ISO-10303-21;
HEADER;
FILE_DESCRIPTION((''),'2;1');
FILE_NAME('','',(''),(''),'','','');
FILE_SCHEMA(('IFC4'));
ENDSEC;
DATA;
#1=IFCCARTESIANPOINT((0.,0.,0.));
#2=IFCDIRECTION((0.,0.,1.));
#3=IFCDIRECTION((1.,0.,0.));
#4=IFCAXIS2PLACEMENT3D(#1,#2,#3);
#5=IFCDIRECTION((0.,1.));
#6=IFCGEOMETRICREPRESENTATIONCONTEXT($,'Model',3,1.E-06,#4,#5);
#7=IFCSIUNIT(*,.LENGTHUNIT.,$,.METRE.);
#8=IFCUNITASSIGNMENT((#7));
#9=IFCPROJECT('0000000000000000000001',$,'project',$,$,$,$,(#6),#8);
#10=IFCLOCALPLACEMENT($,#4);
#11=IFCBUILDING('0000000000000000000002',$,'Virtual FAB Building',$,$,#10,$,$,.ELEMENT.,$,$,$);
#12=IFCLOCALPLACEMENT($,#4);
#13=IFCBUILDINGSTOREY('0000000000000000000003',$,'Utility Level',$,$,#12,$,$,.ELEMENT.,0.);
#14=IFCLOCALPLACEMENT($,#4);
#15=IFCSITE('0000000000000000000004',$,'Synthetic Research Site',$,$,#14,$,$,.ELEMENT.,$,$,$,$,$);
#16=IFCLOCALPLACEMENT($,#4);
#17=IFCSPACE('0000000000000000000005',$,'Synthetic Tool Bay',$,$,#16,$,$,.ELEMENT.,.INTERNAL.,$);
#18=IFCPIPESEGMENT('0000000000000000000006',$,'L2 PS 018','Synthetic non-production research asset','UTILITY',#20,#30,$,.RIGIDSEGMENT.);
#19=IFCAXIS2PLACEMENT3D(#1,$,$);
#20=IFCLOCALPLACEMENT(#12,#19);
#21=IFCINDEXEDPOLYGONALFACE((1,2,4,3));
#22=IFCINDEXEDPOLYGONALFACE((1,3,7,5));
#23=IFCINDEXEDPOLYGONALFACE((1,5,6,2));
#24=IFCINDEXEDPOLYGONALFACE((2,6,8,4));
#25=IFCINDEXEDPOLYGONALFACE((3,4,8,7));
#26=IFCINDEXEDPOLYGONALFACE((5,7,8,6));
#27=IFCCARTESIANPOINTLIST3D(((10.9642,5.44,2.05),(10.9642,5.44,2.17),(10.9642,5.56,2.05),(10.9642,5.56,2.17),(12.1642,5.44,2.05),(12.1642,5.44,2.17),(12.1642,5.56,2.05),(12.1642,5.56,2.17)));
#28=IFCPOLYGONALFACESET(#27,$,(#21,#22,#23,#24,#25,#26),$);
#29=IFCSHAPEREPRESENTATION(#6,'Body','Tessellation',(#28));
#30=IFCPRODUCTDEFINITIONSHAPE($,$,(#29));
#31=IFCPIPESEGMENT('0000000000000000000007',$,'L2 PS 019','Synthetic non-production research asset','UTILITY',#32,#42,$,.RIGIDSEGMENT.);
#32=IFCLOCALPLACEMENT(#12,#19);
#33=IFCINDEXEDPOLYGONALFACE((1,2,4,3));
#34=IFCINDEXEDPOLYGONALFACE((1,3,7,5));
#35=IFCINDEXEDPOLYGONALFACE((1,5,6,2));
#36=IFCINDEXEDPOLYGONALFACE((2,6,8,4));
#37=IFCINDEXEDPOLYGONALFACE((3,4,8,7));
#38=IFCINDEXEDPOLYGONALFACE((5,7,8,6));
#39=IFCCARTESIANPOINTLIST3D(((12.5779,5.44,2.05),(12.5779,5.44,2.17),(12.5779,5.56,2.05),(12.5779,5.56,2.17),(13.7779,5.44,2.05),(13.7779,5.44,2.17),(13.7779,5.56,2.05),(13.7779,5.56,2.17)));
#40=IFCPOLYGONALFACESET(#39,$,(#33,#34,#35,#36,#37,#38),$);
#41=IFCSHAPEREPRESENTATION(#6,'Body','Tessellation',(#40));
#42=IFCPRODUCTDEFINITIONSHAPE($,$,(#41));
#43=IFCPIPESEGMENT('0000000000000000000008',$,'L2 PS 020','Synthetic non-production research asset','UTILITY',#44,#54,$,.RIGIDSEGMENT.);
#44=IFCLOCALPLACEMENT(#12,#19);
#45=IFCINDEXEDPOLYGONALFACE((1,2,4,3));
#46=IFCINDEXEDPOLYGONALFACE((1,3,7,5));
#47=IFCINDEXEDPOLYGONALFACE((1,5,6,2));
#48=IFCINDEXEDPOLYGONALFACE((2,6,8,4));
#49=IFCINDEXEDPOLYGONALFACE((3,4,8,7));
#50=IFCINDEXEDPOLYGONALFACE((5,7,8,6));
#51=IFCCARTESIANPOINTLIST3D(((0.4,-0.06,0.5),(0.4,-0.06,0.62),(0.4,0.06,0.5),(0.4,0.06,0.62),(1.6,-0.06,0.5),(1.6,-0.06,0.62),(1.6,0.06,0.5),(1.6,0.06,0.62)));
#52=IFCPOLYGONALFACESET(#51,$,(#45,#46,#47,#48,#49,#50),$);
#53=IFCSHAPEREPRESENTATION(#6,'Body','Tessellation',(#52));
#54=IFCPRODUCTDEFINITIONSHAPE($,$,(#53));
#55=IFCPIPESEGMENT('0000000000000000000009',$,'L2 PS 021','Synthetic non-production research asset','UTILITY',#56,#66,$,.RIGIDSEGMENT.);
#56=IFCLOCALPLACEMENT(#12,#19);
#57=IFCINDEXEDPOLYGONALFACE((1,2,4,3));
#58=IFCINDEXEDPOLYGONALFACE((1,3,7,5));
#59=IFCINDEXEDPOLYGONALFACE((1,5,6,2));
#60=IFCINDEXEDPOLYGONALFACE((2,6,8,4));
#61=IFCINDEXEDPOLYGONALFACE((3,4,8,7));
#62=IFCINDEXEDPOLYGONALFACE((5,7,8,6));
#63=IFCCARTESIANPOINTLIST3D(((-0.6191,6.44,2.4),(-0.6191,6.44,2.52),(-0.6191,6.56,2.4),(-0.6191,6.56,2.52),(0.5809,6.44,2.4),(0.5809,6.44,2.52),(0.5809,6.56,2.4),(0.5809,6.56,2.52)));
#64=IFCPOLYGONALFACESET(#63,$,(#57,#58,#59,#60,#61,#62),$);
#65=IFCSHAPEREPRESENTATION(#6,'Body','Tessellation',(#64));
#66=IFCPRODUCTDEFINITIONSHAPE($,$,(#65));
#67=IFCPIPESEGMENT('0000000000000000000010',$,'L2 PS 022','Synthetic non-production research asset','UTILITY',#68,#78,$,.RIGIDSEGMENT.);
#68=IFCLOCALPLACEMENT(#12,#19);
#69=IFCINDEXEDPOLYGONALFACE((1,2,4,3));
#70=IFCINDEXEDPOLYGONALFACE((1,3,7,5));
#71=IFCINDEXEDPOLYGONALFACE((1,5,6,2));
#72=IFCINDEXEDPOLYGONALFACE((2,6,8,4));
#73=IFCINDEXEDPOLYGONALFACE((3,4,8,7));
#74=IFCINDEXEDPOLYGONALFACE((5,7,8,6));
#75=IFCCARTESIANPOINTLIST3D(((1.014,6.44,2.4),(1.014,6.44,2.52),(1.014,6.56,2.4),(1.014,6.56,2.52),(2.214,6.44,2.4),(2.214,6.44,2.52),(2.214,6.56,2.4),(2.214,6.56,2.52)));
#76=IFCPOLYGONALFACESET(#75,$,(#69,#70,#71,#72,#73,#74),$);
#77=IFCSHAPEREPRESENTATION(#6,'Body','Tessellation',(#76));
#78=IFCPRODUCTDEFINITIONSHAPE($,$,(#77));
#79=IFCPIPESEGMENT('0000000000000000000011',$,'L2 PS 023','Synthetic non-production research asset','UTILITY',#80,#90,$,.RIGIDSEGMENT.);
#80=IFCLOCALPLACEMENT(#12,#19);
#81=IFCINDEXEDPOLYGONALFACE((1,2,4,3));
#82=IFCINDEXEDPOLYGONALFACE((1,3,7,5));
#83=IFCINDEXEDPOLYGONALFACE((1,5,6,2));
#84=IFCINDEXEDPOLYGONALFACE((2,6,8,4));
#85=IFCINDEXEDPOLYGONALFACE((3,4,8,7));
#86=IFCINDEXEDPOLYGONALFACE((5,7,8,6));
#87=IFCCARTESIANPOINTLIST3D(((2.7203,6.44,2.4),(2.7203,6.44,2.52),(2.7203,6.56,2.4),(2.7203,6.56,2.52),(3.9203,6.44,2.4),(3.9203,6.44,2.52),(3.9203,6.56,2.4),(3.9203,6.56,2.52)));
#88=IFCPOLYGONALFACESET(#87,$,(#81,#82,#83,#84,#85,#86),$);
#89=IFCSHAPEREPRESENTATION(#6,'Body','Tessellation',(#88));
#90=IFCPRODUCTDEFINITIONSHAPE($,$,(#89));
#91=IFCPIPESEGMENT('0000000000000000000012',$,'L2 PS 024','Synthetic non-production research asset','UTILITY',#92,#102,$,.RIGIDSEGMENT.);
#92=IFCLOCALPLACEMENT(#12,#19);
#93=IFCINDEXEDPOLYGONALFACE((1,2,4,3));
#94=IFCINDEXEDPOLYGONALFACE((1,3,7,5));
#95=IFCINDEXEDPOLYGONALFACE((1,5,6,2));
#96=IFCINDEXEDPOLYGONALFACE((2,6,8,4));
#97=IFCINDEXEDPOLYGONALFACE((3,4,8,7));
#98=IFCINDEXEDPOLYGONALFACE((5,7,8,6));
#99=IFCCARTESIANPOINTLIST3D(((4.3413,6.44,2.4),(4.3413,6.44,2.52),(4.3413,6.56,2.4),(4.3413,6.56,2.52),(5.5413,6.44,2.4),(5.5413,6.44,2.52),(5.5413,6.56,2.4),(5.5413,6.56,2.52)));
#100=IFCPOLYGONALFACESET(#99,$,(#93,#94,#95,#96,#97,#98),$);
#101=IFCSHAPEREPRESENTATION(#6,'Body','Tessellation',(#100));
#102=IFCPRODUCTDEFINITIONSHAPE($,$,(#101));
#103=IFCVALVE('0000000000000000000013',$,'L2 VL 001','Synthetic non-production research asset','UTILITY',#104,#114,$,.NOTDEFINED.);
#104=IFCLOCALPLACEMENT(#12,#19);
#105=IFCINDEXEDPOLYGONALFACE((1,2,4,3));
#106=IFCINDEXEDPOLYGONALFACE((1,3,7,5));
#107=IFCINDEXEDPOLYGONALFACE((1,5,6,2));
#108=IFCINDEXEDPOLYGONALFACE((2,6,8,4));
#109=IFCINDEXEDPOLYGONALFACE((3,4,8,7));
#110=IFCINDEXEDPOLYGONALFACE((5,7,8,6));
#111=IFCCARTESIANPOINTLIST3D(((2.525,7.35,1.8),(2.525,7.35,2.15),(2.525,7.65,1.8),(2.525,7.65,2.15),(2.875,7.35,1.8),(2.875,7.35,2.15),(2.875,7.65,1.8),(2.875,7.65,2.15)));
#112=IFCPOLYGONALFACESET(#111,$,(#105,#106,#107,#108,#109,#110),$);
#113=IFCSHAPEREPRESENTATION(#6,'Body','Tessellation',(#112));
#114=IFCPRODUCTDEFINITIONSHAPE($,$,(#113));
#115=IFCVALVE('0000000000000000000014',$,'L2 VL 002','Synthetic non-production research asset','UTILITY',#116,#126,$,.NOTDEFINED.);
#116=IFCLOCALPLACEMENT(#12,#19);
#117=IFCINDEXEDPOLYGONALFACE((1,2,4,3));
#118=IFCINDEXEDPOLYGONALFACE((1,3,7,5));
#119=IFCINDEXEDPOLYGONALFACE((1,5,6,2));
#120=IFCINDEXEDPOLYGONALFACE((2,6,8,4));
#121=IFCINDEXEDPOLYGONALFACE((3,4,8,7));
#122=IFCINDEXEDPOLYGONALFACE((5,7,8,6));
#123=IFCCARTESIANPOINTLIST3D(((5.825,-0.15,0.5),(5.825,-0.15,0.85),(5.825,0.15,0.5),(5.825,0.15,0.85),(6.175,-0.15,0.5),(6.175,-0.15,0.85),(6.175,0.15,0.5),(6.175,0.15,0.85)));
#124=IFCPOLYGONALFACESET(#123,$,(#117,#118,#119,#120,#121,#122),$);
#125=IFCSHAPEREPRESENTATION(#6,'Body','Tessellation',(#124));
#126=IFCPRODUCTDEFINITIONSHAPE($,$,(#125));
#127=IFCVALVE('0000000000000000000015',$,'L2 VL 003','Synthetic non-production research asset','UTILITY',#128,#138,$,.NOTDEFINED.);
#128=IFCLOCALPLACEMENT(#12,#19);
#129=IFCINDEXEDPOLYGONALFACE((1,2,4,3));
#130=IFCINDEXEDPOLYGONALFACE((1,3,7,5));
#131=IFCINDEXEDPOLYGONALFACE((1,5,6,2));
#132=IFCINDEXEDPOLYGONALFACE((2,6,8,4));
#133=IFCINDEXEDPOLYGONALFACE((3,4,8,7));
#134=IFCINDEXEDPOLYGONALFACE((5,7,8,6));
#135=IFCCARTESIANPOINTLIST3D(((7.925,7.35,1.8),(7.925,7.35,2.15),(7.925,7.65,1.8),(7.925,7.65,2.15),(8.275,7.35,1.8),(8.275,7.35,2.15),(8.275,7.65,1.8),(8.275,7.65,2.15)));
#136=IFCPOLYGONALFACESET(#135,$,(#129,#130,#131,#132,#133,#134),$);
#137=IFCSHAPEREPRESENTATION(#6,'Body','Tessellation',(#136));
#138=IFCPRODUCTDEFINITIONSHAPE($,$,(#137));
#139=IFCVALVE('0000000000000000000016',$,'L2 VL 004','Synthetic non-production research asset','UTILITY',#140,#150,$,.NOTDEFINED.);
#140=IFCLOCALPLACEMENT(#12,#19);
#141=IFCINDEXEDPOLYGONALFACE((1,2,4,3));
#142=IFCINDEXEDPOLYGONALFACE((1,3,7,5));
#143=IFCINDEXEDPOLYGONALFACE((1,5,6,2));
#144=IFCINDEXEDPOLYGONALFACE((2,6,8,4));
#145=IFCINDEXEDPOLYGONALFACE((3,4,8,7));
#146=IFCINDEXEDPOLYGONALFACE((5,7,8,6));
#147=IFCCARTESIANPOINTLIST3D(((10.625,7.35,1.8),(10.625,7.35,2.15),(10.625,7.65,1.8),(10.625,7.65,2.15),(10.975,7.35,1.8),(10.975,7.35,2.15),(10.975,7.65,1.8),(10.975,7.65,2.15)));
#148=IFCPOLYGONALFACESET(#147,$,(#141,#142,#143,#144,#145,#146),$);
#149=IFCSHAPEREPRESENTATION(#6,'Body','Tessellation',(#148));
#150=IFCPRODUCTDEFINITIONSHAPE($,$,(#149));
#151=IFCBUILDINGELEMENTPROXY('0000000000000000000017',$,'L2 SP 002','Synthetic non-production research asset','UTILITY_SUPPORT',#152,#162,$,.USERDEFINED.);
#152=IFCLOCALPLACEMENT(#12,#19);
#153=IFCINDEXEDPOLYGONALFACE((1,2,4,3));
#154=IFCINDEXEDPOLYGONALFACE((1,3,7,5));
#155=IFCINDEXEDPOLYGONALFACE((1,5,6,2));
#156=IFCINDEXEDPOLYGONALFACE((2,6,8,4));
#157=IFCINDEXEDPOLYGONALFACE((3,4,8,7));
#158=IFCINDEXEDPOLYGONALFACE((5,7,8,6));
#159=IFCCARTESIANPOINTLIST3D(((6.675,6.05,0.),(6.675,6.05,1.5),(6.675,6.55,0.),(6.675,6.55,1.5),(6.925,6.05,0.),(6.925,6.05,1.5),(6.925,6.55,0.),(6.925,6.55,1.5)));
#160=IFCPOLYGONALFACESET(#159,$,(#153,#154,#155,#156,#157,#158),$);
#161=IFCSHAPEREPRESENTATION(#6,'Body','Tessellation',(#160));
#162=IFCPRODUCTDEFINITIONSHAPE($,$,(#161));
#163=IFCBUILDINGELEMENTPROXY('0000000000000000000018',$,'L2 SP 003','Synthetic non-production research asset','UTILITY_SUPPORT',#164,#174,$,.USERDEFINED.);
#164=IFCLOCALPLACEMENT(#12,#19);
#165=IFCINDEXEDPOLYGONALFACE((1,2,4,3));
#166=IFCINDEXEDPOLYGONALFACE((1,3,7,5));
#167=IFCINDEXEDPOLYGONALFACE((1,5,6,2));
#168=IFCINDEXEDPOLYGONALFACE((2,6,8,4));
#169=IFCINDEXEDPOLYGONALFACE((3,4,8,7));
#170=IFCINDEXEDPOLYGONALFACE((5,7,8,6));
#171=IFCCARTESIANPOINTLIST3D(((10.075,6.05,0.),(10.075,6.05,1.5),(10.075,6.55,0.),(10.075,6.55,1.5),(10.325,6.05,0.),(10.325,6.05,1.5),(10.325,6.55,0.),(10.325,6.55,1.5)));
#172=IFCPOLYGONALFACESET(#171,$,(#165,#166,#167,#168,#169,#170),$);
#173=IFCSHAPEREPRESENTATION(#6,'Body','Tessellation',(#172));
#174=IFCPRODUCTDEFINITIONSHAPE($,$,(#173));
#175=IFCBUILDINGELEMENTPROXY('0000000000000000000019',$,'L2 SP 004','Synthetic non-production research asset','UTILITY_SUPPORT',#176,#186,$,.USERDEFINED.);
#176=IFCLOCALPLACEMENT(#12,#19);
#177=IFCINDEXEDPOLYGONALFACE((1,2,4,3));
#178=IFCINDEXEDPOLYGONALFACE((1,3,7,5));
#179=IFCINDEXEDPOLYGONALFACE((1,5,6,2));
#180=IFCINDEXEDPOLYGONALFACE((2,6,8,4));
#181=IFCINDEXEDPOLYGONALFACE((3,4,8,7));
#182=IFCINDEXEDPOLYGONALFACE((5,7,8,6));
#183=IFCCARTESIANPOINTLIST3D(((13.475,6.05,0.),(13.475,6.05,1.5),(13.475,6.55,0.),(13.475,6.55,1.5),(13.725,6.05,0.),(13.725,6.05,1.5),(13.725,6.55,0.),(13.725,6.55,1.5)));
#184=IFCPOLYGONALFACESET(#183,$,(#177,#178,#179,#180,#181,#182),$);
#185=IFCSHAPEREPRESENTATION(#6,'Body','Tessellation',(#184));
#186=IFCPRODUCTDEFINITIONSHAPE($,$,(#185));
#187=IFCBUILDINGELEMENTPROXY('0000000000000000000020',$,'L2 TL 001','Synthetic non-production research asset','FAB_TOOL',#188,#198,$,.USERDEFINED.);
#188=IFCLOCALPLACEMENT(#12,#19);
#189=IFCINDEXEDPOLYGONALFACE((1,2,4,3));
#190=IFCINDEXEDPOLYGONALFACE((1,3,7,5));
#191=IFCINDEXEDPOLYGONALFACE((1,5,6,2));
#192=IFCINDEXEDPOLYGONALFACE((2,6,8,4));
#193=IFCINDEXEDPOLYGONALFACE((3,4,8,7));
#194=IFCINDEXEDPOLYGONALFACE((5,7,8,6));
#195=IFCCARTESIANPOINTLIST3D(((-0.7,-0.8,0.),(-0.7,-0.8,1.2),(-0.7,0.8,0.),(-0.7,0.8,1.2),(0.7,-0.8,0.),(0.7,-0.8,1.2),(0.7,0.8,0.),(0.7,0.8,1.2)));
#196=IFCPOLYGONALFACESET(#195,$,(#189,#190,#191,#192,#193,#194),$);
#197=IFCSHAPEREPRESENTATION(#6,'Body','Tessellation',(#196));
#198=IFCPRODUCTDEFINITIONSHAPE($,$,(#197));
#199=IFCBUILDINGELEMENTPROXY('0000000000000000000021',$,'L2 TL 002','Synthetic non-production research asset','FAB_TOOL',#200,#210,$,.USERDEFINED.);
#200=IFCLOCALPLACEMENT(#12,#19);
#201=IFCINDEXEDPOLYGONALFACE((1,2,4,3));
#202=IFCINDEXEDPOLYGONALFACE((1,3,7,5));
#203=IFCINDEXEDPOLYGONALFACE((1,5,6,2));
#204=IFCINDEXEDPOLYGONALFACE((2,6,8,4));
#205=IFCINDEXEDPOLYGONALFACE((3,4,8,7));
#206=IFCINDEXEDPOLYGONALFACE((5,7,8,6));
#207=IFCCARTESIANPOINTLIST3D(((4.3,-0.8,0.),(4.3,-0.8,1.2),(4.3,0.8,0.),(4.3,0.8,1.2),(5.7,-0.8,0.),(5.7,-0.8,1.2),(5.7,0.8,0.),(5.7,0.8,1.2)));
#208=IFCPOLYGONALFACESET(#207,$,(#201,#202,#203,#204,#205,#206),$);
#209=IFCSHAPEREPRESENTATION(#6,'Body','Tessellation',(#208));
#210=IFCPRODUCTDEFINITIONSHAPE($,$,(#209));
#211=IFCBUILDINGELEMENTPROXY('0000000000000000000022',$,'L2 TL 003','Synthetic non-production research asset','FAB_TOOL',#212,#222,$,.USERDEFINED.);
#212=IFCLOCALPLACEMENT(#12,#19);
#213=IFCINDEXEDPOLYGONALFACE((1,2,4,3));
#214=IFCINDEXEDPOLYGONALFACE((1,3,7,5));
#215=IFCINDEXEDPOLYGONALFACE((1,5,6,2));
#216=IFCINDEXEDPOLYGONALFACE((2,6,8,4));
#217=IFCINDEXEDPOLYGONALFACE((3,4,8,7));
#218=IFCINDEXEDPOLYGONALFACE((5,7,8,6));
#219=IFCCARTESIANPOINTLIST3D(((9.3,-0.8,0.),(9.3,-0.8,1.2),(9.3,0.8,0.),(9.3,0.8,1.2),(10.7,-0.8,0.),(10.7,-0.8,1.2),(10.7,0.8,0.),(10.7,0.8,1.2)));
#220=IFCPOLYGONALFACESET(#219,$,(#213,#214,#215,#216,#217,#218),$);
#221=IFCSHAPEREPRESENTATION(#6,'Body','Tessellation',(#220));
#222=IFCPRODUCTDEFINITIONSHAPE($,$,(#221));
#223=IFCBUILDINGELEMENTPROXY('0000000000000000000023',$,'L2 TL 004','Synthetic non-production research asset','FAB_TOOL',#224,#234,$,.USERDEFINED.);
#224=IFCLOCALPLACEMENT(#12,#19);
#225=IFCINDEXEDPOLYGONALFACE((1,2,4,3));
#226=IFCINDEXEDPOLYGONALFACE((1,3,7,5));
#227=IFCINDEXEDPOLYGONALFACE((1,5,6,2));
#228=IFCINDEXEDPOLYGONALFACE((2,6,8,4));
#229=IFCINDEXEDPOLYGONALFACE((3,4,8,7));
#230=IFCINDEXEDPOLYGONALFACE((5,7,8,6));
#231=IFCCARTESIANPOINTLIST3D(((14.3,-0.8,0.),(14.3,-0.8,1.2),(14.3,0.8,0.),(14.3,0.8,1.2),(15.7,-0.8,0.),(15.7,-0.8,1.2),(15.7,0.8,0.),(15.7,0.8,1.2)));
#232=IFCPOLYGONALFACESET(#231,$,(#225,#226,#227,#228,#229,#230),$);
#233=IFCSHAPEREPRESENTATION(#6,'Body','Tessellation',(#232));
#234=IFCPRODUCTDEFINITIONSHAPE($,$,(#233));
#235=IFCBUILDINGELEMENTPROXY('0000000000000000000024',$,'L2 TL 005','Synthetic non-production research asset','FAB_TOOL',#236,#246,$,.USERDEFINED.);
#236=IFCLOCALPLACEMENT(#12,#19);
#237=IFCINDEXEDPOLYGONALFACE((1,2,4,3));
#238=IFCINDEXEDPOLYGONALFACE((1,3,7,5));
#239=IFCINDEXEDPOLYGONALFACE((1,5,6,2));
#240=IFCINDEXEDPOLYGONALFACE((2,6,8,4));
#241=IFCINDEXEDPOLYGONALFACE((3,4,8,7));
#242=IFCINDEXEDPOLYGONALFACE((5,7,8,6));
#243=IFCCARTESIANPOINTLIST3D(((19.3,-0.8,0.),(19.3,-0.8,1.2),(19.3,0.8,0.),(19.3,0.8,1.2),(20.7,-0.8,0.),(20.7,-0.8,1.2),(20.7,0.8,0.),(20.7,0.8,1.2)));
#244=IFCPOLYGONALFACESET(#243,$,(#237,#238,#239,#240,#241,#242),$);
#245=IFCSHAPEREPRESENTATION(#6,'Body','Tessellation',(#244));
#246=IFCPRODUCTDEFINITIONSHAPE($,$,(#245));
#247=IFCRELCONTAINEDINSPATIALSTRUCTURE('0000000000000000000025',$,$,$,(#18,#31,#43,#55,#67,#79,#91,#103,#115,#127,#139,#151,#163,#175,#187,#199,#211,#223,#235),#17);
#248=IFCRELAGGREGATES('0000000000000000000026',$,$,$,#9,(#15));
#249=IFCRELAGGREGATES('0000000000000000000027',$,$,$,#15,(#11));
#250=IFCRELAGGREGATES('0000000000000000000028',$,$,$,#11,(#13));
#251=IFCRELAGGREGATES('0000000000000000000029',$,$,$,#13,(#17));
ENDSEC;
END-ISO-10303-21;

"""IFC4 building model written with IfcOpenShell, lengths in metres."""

from ifc_helpers import new_model, si_unit, direction, frame, origin_with_axes, origin_2d_with_axis, place, context, project, spatial, rectangle, extrude, element, save


model = new_model("IFC4")

# Units and contexts
model_context = context("Model", 3, precision=1e-06, world=origin_with_axes(), true_north=direction((0.0, 1.0)))
ifc_project = project(units=[si_unit("LENGTHUNIT", "METRE")], contexts=[model_context])

# Site, building, storey, space
site_placement = place(None, origin_with_axes())
site = spatial("IfcSite", under=ifc_project, at=site_placement, Name="Synthetic Research Site", CompositionType="ELEMENT")
building_placement = place(None, origin_with_axes())
building = spatial("IfcBuilding", under=site, at=building_placement, Name="Virtual FAB Building", CompositionType="ELEMENT")
storey_placement = place(None, origin_with_axes())
storey = spatial("IfcBuildingStorey", under=building, at=storey_placement, Name="Utility Level", CompositionType="ELEMENT", Elevation=0.0)
space_placement = place(None, origin_with_axes())
space = spatial("IfcSpace", under=storey, at=space_placement, Name="Synthetic Tool Bay", CompositionType="ELEMENT", PredefinedType="INTERNAL")

# Pipe segments
for number, where, z_axis, x_axis, name in (
    (1, (11.5642, 5.5, 2.05), (0.0, 0.0, 1.0), (1.0, 0.0, 0.0), "L2 PS 018"),
    (2, (13.1779, 5.5, 2.05), (0.0, 0.0, 1.0), (1.0, 0.0, 0.0), "L2 PS 019"),
    (3, (1.0, 0.0, 0.5), (0.0, 0.0, 1.0), (1.0, 0.0, 0.0), "L2 PS 020"),
    (4, (-0.0191, 6.5, 2.4), (0.0, 0.0, 1.0), (1.0, 0.0, 0.0), "L2 PS 021"),
    (5, (1.614, 6.5, 2.4), (0.0, 0.0, 1.0), (1.0, 0.0, 0.0), "L2 PS 022"),
    (6, (3.3203, 6.5, 2.4), (0.0, 0.0, 1.0), (1.0, 0.0, 0.0), "L2 PS 023"),
    (7, (4.9413, 6.5, 2.4), (0.0, 0.0, 1.0), (1.0, 0.0, 0.0), "L2 PS 024"),
):
    element("IfcPipeSegment", number, at=place(None, frame(where, z_axis=z_axis, x_axis=x_axis)), inside=space, Name=name, Description="Synthetic non-production research asset", ObjectType="UTILITY", PredefinedType="RIGIDSEGMENT", context=model_context, shape_type="SweptSolid", body=[
        extrude(rectangle(XDim=1.2, YDim=0.12, at=origin_2d_with_axis()), origin_with_axes(), (0.0, 0.0, 1.0), 0.12),
    ])

# Valves
for number, where, z_axis, x_axis, name in (
    (8, (2.7, 7.5, 1.8), (0.0, 0.0, 1.0), (1.0, 0.0, 0.0), "L2 VL 001"),
    (9, (6.0, 0.0, 0.5), (0.0, 0.0, 1.0), (1.0, 0.0, 0.0), "L2 VL 002"),
    (10, (8.1, 7.5, 1.8), (0.0, 0.0, 1.0), (1.0, 0.0, 0.0), "L2 VL 003"),
    (11, (10.8, 7.5, 1.8), (0.0, 0.0, 1.0), (1.0, 0.0, 0.0), "L2 VL 004"),
):
    element("IfcValve", number, at=place(None, frame(where, z_axis=z_axis, x_axis=x_axis)), inside=space, Name=name, Description="Synthetic non-production research asset", ObjectType="UTILITY", PredefinedType="NOTDEFINED", context=model_context, shape_type="SweptSolid", body=[
        extrude(rectangle(XDim=0.35, YDim=0.3, at=origin_2d_with_axis()), origin_with_axes(), (0.0, 0.0, 1.0), 0.35),
    ])

# Building element proxies
for number, where, z_axis, x_axis, name in (
    (12, (6.8, 6.3, 0.0), (0.0, 0.0, 1.0), (1.0, 0.0, 0.0), "L2 SP 002"),
    (13, (10.2, 6.3, 0.0), (0.0, 0.0, 1.0), (1.0, 0.0, 0.0), "L2 SP 003"),
    (14, (13.6, 6.3, 0.0), (0.0, 0.0, 1.0), (1.0, 0.0, 0.0), "L2 SP 004"),
):
    element("IfcBuildingElementProxy", number, at=place(None, frame(where, z_axis=z_axis, x_axis=x_axis)), inside=space, Name=name, Description="Synthetic non-production research asset", ObjectType="UTILITY_SUPPORT", PredefinedType="USERDEFINED", context=model_context, shape_type="SweptSolid", body=[
        extrude(rectangle(XDim=0.25, YDim=0.5, at=origin_2d_with_axis()), origin_with_axes(), (0.0, 0.0, 1.0), 1.5),
    ])
for number, where, z_axis, x_axis, name in (
    (15, (0.0, 0.0, 0.0), (0.0, 0.0, 1.0), (1.0, 0.0, 0.0), "L2 TL 001"),
    (16, (5.0, 0.0, 0.0), (0.0, 0.0, 1.0), (1.0, 0.0, 0.0), "L2 TL 002"),
    (17, (10.0, 0.0, 0.0), (0.0, 0.0, 1.0), (1.0, 0.0, 0.0), "L2 TL 003"),
    (18, (15.0, 0.0, 0.0), (0.0, 0.0, 1.0), (1.0, 0.0, 0.0), "L2 TL 004"),
    (19, (20.0, 0.0, 0.0), (0.0, 0.0, 1.0), (1.0, 0.0, 0.0), "L2 TL 005"),
):
    element("IfcBuildingElementProxy", number, at=place(None, frame(where, z_axis=z_axis, x_axis=x_axis)), inside=space, Name=name, Description="Synthetic non-production research asset", ObjectType="FAB_TOOL", PredefinedType="USERDEFINED", context=model_context, shape_type="SweptSolid", body=[
        extrude(rectangle(XDim=1.4, YDim=1.6, at=origin_2d_with_axis()), origin_with_axes(), (0.0, 0.0, 1.0), 1.2),
    ])

save(model, "model.ifc")
